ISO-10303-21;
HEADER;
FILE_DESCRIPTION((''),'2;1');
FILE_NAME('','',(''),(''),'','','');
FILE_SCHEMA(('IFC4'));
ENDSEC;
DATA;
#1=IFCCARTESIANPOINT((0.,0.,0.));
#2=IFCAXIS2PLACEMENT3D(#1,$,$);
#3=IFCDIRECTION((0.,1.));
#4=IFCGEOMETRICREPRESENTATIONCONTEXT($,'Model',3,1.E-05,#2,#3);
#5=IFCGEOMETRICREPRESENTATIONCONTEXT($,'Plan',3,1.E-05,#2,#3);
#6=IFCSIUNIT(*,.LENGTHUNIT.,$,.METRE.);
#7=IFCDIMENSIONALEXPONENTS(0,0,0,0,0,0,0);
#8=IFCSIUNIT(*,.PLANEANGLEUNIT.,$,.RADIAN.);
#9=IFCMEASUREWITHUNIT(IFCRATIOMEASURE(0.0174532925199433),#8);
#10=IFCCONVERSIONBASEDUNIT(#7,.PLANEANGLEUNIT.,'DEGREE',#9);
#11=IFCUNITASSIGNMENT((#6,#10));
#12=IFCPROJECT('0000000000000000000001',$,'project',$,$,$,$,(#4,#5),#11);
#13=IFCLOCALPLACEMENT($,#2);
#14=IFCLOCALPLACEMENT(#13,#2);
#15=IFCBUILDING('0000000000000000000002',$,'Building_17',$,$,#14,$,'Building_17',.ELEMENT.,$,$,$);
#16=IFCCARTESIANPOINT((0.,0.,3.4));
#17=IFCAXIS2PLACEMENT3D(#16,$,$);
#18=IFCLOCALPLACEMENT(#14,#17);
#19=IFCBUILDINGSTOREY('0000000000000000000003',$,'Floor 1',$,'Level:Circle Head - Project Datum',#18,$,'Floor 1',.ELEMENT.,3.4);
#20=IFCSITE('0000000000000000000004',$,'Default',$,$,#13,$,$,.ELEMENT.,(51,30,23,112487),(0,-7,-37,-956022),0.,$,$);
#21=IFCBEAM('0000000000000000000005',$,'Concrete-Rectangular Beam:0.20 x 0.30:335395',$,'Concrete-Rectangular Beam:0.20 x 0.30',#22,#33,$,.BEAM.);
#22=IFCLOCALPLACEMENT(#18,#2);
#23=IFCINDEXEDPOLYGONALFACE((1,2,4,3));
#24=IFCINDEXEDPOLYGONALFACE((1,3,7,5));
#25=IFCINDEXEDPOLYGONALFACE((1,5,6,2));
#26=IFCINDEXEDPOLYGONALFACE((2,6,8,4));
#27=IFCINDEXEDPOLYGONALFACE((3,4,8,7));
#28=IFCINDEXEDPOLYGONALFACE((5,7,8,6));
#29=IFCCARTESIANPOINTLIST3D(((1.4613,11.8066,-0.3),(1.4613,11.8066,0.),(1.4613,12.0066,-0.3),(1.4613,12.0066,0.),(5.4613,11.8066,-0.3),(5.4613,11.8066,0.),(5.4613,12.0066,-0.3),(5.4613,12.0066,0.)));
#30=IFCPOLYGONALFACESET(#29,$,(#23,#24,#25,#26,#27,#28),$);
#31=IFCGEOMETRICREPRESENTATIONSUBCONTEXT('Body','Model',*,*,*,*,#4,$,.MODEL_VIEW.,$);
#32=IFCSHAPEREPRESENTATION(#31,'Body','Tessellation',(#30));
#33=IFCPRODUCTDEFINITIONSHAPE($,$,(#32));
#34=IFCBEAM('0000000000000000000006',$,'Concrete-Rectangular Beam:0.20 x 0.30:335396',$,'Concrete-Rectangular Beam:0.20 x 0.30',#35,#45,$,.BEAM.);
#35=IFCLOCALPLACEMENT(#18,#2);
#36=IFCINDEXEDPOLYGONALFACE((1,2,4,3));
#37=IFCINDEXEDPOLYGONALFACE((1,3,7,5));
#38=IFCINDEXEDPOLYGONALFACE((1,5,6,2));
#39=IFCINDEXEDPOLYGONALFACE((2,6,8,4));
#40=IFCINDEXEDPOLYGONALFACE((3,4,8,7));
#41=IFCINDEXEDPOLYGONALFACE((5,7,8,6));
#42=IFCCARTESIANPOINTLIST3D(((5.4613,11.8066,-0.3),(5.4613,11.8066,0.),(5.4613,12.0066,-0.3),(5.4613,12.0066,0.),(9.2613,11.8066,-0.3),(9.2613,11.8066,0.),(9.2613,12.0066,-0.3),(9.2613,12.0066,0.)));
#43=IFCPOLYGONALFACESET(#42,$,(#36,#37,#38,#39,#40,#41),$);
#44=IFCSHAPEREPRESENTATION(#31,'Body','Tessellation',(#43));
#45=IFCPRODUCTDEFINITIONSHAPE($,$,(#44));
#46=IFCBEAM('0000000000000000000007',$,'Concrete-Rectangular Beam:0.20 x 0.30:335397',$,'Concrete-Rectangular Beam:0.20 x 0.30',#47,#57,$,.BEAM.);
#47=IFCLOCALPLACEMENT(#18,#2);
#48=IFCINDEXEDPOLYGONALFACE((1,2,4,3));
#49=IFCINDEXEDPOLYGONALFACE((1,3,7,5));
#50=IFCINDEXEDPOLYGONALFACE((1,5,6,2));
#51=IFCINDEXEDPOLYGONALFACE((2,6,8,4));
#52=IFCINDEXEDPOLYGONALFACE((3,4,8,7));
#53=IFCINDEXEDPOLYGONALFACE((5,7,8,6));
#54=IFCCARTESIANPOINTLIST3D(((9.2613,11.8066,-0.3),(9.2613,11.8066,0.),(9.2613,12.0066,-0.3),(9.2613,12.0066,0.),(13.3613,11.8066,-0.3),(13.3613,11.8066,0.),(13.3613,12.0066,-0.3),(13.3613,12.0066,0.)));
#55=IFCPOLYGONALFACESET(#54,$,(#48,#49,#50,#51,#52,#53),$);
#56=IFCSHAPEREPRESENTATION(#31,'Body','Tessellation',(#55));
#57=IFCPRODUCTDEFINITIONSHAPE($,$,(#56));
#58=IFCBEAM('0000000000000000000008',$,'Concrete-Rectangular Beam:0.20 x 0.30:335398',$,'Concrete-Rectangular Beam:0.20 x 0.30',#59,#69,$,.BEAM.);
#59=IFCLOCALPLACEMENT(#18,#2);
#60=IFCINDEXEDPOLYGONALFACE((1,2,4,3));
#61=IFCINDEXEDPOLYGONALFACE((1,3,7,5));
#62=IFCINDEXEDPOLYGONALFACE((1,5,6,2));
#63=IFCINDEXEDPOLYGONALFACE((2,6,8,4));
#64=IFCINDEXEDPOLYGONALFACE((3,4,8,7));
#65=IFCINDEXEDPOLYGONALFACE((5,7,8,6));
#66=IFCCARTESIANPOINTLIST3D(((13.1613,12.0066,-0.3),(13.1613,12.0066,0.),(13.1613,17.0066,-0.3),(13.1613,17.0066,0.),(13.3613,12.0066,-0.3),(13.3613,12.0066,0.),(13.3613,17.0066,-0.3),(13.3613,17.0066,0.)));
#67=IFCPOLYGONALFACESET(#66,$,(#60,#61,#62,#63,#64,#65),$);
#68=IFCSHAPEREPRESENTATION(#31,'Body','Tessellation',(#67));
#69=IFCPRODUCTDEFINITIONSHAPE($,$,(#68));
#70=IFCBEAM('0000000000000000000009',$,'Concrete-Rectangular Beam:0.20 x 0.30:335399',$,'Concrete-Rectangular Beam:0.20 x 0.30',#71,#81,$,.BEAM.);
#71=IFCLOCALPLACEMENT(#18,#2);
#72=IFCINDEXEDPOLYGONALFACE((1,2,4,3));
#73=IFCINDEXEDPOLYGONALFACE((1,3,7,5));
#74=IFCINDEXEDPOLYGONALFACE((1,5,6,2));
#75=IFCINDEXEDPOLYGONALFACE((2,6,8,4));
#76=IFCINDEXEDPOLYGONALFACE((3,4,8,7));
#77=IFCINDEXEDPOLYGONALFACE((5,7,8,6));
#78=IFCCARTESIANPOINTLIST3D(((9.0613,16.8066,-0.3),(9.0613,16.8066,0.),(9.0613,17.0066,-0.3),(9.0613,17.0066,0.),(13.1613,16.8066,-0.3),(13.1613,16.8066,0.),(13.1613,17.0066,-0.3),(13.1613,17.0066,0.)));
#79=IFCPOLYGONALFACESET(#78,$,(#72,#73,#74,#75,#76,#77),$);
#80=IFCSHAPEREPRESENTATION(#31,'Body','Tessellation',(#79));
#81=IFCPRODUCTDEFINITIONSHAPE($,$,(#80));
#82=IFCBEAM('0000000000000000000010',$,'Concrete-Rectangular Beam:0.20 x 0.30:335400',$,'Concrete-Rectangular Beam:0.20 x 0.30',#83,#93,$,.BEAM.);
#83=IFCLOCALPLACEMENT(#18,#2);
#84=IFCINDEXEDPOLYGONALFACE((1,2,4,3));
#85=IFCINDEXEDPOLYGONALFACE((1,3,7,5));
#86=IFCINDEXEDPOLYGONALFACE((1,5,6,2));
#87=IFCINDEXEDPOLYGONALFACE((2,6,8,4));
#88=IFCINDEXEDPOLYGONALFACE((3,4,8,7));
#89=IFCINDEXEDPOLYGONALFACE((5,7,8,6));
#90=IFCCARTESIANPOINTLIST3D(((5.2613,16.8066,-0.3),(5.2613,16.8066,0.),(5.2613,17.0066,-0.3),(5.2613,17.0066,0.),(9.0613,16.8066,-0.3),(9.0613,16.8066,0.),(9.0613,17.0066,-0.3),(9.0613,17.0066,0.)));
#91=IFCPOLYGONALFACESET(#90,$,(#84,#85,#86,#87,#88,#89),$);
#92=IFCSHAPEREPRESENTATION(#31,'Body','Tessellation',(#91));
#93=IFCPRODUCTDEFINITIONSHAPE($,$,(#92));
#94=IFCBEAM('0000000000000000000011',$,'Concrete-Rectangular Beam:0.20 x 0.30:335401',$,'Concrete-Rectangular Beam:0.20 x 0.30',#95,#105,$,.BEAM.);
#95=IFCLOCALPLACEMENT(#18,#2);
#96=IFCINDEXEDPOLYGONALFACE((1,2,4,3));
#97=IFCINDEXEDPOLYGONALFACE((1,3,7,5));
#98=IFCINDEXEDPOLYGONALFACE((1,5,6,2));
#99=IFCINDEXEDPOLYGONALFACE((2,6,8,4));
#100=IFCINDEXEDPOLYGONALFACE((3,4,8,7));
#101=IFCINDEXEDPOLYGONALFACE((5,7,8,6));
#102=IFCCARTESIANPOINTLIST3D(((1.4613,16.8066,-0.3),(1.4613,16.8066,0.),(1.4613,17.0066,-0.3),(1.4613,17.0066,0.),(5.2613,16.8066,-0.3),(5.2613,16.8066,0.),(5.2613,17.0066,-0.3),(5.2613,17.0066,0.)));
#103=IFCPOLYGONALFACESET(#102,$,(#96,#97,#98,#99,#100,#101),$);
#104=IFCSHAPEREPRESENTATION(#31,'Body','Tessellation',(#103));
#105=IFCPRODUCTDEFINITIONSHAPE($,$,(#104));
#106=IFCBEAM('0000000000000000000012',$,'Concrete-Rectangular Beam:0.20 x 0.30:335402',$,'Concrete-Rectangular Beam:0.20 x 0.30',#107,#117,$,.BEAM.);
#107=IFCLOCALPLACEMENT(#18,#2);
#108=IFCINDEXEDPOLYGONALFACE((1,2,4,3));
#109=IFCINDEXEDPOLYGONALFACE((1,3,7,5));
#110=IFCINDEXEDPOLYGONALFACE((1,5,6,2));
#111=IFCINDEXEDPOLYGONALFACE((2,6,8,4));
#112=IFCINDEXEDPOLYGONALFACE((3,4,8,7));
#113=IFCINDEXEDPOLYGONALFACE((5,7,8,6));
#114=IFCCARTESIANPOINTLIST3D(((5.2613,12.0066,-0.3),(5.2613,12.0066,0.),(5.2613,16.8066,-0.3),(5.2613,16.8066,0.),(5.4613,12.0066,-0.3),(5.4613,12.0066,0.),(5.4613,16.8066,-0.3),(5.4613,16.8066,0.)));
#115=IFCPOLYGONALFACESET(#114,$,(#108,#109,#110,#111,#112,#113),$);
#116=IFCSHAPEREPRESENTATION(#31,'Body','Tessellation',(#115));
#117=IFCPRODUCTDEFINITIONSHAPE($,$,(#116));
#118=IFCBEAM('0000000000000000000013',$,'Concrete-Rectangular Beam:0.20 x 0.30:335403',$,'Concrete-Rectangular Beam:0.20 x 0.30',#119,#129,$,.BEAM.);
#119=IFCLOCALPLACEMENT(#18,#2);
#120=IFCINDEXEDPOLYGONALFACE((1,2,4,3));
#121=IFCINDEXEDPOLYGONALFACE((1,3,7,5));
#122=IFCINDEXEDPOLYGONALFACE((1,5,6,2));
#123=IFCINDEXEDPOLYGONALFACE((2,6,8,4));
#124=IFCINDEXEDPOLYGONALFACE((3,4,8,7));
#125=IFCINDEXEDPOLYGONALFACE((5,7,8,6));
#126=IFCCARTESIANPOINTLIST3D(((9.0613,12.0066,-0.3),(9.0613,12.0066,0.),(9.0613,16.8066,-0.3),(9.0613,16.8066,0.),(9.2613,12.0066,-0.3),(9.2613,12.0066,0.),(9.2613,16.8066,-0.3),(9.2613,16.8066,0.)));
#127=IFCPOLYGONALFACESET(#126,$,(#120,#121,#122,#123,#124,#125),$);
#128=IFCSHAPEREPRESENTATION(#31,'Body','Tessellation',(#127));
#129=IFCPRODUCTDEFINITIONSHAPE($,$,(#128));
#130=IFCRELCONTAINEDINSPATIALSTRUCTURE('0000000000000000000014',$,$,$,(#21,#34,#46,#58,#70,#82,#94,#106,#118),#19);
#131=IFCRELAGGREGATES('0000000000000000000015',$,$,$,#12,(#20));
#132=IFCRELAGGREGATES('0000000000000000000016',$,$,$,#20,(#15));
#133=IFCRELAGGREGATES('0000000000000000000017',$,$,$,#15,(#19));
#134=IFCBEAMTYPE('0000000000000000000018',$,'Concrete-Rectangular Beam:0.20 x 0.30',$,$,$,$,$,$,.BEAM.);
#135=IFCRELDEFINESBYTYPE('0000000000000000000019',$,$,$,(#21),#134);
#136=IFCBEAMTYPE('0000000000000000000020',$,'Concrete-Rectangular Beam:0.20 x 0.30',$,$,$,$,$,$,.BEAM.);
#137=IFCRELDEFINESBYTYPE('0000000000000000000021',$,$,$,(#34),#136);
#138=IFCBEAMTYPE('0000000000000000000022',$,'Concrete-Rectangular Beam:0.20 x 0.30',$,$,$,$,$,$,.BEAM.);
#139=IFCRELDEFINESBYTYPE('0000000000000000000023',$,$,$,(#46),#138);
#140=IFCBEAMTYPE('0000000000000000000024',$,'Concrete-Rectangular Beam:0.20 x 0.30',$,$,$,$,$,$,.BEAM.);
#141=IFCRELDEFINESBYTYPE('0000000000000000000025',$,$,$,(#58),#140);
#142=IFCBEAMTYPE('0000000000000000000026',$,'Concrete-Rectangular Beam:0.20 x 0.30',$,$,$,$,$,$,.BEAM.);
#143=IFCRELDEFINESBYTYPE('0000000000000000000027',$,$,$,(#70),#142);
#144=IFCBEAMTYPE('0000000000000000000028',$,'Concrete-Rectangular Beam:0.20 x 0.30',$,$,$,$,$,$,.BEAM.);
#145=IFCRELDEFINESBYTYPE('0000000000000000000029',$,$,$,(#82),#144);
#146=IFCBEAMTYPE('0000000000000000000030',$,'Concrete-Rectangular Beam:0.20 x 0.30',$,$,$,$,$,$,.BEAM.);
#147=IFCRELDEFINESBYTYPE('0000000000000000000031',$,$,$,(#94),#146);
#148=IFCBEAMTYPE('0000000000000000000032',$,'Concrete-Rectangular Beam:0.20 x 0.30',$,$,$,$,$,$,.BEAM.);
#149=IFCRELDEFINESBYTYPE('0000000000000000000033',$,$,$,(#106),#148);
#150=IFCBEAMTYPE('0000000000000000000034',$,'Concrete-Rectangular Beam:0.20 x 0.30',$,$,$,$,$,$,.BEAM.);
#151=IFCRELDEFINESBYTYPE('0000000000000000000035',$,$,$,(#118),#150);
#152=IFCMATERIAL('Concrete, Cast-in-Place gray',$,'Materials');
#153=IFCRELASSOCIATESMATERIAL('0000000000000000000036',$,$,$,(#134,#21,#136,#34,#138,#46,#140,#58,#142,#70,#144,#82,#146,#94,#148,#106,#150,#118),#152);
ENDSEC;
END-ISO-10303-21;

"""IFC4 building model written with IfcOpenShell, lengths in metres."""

from ifc_helpers import new_model, entity, si_unit, converted_unit, direction, frame, origin, place, context, subcontext, project, spatial, indexed_curve, outline, extrude, source, transform, mapped, material, type_object, type_shapes, element, save


model = new_model("IFC4")

# Units and contexts
model_context = context("Model", 3, precision=1e-05, world=origin(), true_north=direction((0.0, 1.0)))
plan_context = context("Plan", 3, precision=1e-05, world=origin(), true_north=direction((0.0, 1.0)))
body_context = subcontext(model_context, "Body", "Model", "MODEL_VIEW")
ifc_project = project(units=[si_unit("LENGTHUNIT", "METRE"), converted_unit("PLANEANGLEUNIT", "DEGREE", entity("IfcRatioMeasure", 0.0174532925199433), si_unit("PLANEANGLEUNIT", "RADIAN"), dimensions=[0, 0, 0, 0, 0, 0, 0])], contexts=[model_context, plan_context])

# Site, building, storey
site_placement = place(None, origin())
site = spatial("IfcSite", under=ifc_project, at=site_placement, Name="Default", CompositionType="ELEMENT", RefLatitude=(51, 30, 23, 112487), RefLongitude=(0, -7, -37, -956022), RefElevation=0.0)
building_placement = place(site_placement, origin())
building = spatial("IfcBuilding", under=site, at=building_placement, Name="Building_17", LongName="Building_17", CompositionType="ELEMENT")
storey_placement = place(building_placement, frame((0.0, 0.0, 3.4)))
storey = spatial("IfcBuildingStorey", under=building, at=storey_placement, Name="Floor 1", ObjectType="Level:Circle Head - Project Datum", LongName="Floor 1", CompositionType="ELEMENT", Elevation=3.4)

# Beams
ifc_material_1 = material(Name="Concrete, Cast-in-Place gray", Category="Materials")
beam_type_1 = type_object("IfcBeamType", Name="Concrete-Rectangular Beam:0.20 x 0.30", PredefinedType="BEAM", material=ifc_material_1)
shared_shape_1 = source(origin(), body_context, "Body", "SweptSolid", [
    extrude(outline(indexed_curve([(-0.15, -0.1), (0.15, -0.1), (0.15, 0.1), (-0.15, 0.1), (-0.15, -0.1)], self_intersect=False)), frame((1.4613, 11.9066, 3.25), z_axis=(1.0, 0.0, 0.0), x_axis=(0.0, 0.0, -1.0)), (0.0, 0.0, 1.0), 4.0),
])
type_shapes(beam_type_1, [shared_shape_1])
beam_1_placement = place(storey_placement, frame((0.0, 0.0, -3.4)))
element("IfcBeam", 1, at=beam_1_placement, inside=storey, type_object=beam_type_1, material=ifc_material_1, Name="Concrete-Rectangular Beam:0.20 x 0.30:335395", ObjectType="Concrete-Rectangular Beam:0.20 x 0.30", PredefinedType="BEAM", context=body_context, shape_type="MappedRepresentation", body=[
    mapped(shared_shape_1, transform((0.0, 0.0, 0.0), scale=1.0)),
])
beam_type_2 = type_object("IfcBeamType", Name="Concrete-Rectangular Beam:0.20 x 0.30", PredefinedType="BEAM", material=ifc_material_1)
shared_shape_2 = source(origin(), body_context, "Body", "SweptSolid", [
    extrude(outline(indexed_curve([(-0.15, -0.1), (0.15, -0.1), (0.15, 0.1), (-0.15, 0.1), (-0.15, -0.1)], self_intersect=False)), frame((5.4613, 11.9066, 3.25), z_axis=(1.0, 0.0, 0.0), x_axis=(0.0, 0.0, -1.0)), (0.0, 0.0, 1.0), 3.8),
])
type_shapes(beam_type_2, [shared_shape_2])
beam_2_placement = place(storey_placement, frame((0.0, 0.0, -3.4)))
element("IfcBeam", 2, at=beam_2_placement, inside=storey, type_object=beam_type_2, material=ifc_material_1, Name="Concrete-Rectangular Beam:0.20 x 0.30:335396", ObjectType="Concrete-Rectangular Beam:0.20 x 0.30", PredefinedType="BEAM", context=body_context, shape_type="MappedRepresentation", body=[
    mapped(shared_shape_2, transform((0.0, 0.0, 0.0), scale=1.0)),
])
beam_type_3 = type_object("IfcBeamType", Name="Concrete-Rectangular Beam:0.20 x 0.30", PredefinedType="BEAM", material=ifc_material_1)
shared_shape_3 = source(origin(), body_context, "Body", "SweptSolid", [
    extrude(outline(indexed_curve([(-0.15, -0.1), (0.15, -0.1), (0.15, 0.1), (-0.15, 0.1), (-0.15, -0.1)], self_intersect=False)), frame((9.2613, 11.9066, 3.25), z_axis=(1.0, 0.0, 0.0), x_axis=(0.0, 0.0, -1.0)), (0.0, 0.0, 1.0), 4.1),
])
type_shapes(beam_type_3, [shared_shape_3])
beam_3_placement = place(storey_placement, frame((0.0, 0.0, -3.4)))
element("IfcBeam", 3, at=beam_3_placement, inside=storey, type_object=beam_type_3, material=ifc_material_1, Name="Concrete-Rectangular Beam:0.20 x 0.30:335397", ObjectType="Concrete-Rectangular Beam:0.20 x 0.30", PredefinedType="BEAM", context=body_context, shape_type="MappedRepresentation", body=[
    mapped(shared_shape_3, transform((0.0, 0.0, 0.0), scale=1.0)),
])
beam_type_4 = type_object("IfcBeamType", Name="Concrete-Rectangular Beam:0.20 x 0.30", PredefinedType="BEAM", material=ifc_material_1)
shared_shape_4 = source(origin(), body_context, "Body", "SweptSolid", [
    extrude(outline(indexed_curve([(-0.1, -0.15), (0.1, -0.15), (0.1, 0.15), (-0.1, 0.15), (-0.1, -0.15)], self_intersect=False)), frame((13.2613, 12.0066, 3.25), z_axis=(0.0, 1.0, 0.0), x_axis=(-1.0, 0.0, 0.0)), (0.0, 0.0, 1.0), 5.0),
])
type_shapes(beam_type_4, [shared_shape_4])
beam_4_placement = place(storey_placement, frame((0.0, 0.0, -3.4)))
element("IfcBeam", 4, at=beam_4_placement, inside=storey, type_object=beam_type_4, material=ifc_material_1, Name="Concrete-Rectangular Beam:0.20 x 0.30:335398", ObjectType="Concrete-Rectangular Beam:0.20 x 0.30", PredefinedType="BEAM", context=body_context, shape_type="MappedRepresentation", body=[
    mapped(shared_shape_4, transform((0.0, 0.0, 0.0), scale=1.0)),
])
beam_type_5 = type_object("IfcBeamType", Name="Concrete-Rectangular Beam:0.20 x 0.30", PredefinedType="BEAM", material=ifc_material_1)
shared_shape_5 = source(origin(), body_context, "Body", "SweptSolid", [
    extrude(outline(indexed_curve([(-0.15, -0.1), (0.15, -0.1), (0.15, 0.1), (-0.15, 0.1), (-0.15, -0.1)], self_intersect=False)), frame((13.1613, 16.9066, 3.25), z_axis=(-1.0, 0.0, 0.0), x_axis=(0.0, 0.0, -1.0)), (0.0, 0.0, 1.0), 4.1),
])
type_shapes(beam_type_5, [shared_shape_5])
beam_5_placement = place(storey_placement, frame((0.0, 0.0, -3.4)))
element("IfcBeam", 5, at=beam_5_placement, inside=storey, type_object=beam_type_5, material=ifc_material_1, Name="Concrete-Rectangular Beam:0.20 x 0.30:335399", ObjectType="Concrete-Rectangular Beam:0.20 x 0.30", PredefinedType="BEAM", context=body_context, shape_type="MappedRepresentation", body=[
    mapped(shared_shape_5, transform((0.0, 0.0, 0.0), scale=1.0)),
])
beam_type_6 = type_object("IfcBeamType", Name="Concrete-Rectangular Beam:0.20 x 0.30", PredefinedType="BEAM", material=ifc_material_1)
shared_shape_6 = source(origin(), body_context, "Body", "SweptSolid", [
    extrude(outline(indexed_curve([(-0.15, -0.1), (0.15, -0.1), (0.15, 0.1), (-0.15, 0.1), (-0.15, -0.1)], self_intersect=False)), frame((9.0613, 16.9066, 3.25), z_axis=(-1.0, 0.0, 0.0), x_axis=(0.0, 0.0, -1.0)), (0.0, 0.0, 1.0), 3.8),
])
type_shapes(beam_type_6, [shared_shape_6])
beam_6_placement = place(storey_placement, frame((0.0, 0.0, -3.4)))
element("IfcBeam", 6, at=beam_6_placement, inside=storey, type_object=beam_type_6, material=ifc_material_1, Name="Concrete-Rectangular Beam:0.20 x 0.30:335400", ObjectType="Concrete-Rectangular Beam:0.20 x 0.30", PredefinedType="BEAM", context=body_context, shape_type="MappedRepresentation", body=[
    mapped(shared_shape_6, transform((0.0, 0.0, 0.0), scale=1.0)),
])
beam_type_7 = type_object("IfcBeamType", Name="Concrete-Rectangular Beam:0.20 x 0.30", PredefinedType="BEAM", material=ifc_material_1)
shared_shape_7 = source(origin(), body_context, "Body", "SweptSolid", [
    extrude(outline(indexed_curve([(-0.15, -0.1), (0.15, -0.1), (0.15, 0.1), (-0.15, 0.1), (-0.15, -0.1)], self_intersect=False)), frame((5.2613, 16.9066, 3.25), z_axis=(-1.0, 0.0, 0.0), x_axis=(0.0, 0.0, -1.0)), (0.0, 0.0, 1.0), 3.8),
])
type_shapes(beam_type_7, [shared_shape_7])
beam_7_placement = place(storey_placement, frame((0.0, 0.0, -3.4)))
element("IfcBeam", 7, at=beam_7_placement, inside=storey, type_object=beam_type_7, material=ifc_material_1, Name="Concrete-Rectangular Beam:0.20 x 0.30:335401", ObjectType="Concrete-Rectangular Beam:0.20 x 0.30", PredefinedType="BEAM", context=body_context, shape_type="MappedRepresentation", body=[
    mapped(shared_shape_7, transform((0.0, 0.0, 0.0), scale=1.0)),
])
beam_type_8 = type_object("IfcBeamType", Name="Concrete-Rectangular Beam:0.20 x 0.30", PredefinedType="BEAM", material=ifc_material_1)
shared_shape_8 = source(origin(), body_context, "Body", "SweptSolid", [
    extrude(outline(indexed_curve([(-0.1, -0.15), (0.1, -0.15), (0.1, 0.15), (-0.1, 0.15), (-0.1, -0.15)], self_intersect=False)), frame((5.3613, 16.8066, 3.25), z_axis=(0.0, -1.0, 0.0), x_axis=(-1.0, 0.0, 0.0)), (0.0, 0.0, 1.0), 4.8),
])
type_shapes(beam_type_8, [shared_shape_8])
beam_8_placement = place(storey_placement, frame((0.0, 0.0, -3.4)))
element("IfcBeam", 8, at=beam_8_placement, inside=storey, type_object=beam_type_8, material=ifc_material_1, Name="Concrete-Rectangular Beam:0.20 x 0.30:335402", ObjectType="Concrete-Rectangular Beam:0.20 x 0.30", PredefinedType="BEAM", context=body_context, shape_type="MappedRepresentation", body=[
    mapped(shared_shape_8, transform((0.0, 0.0, 0.0), scale=1.0)),
])
beam_type_9 = type_object("IfcBeamType", Name="Concrete-Rectangular Beam:0.20 x 0.30", PredefinedType="BEAM", material=ifc_material_1)
shared_shape_9 = source(origin(), body_context, "Body", "SweptSolid", [
    extrude(outline(indexed_curve([(-0.1, -0.15), (0.1, -0.15), (0.1, 0.15), (-0.1, 0.15), (-0.1, -0.15)], self_intersect=False)), frame((9.1613, 16.8066, 3.25), z_axis=(0.0, -1.0, 0.0), x_axis=(-1.0, 0.0, 0.0)), (0.0, 0.0, 1.0), 4.8),
])
type_shapes(beam_type_9, [shared_shape_9])
beam_9_placement = place(storey_placement, frame((0.0, 0.0, -3.4)))
element("IfcBeam", 9, at=beam_9_placement, inside=storey, type_object=beam_type_9, material=ifc_material_1, Name="Concrete-Rectangular Beam:0.20 x 0.30:335403", ObjectType="Concrete-Rectangular Beam:0.20 x 0.30", PredefinedType="BEAM", context=body_context, shape_type="MappedRepresentation", body=[
    mapped(shared_shape_9, transform((0.0, 0.0, 0.0), scale=1.0)),
])

save(model, "model.ifc")
